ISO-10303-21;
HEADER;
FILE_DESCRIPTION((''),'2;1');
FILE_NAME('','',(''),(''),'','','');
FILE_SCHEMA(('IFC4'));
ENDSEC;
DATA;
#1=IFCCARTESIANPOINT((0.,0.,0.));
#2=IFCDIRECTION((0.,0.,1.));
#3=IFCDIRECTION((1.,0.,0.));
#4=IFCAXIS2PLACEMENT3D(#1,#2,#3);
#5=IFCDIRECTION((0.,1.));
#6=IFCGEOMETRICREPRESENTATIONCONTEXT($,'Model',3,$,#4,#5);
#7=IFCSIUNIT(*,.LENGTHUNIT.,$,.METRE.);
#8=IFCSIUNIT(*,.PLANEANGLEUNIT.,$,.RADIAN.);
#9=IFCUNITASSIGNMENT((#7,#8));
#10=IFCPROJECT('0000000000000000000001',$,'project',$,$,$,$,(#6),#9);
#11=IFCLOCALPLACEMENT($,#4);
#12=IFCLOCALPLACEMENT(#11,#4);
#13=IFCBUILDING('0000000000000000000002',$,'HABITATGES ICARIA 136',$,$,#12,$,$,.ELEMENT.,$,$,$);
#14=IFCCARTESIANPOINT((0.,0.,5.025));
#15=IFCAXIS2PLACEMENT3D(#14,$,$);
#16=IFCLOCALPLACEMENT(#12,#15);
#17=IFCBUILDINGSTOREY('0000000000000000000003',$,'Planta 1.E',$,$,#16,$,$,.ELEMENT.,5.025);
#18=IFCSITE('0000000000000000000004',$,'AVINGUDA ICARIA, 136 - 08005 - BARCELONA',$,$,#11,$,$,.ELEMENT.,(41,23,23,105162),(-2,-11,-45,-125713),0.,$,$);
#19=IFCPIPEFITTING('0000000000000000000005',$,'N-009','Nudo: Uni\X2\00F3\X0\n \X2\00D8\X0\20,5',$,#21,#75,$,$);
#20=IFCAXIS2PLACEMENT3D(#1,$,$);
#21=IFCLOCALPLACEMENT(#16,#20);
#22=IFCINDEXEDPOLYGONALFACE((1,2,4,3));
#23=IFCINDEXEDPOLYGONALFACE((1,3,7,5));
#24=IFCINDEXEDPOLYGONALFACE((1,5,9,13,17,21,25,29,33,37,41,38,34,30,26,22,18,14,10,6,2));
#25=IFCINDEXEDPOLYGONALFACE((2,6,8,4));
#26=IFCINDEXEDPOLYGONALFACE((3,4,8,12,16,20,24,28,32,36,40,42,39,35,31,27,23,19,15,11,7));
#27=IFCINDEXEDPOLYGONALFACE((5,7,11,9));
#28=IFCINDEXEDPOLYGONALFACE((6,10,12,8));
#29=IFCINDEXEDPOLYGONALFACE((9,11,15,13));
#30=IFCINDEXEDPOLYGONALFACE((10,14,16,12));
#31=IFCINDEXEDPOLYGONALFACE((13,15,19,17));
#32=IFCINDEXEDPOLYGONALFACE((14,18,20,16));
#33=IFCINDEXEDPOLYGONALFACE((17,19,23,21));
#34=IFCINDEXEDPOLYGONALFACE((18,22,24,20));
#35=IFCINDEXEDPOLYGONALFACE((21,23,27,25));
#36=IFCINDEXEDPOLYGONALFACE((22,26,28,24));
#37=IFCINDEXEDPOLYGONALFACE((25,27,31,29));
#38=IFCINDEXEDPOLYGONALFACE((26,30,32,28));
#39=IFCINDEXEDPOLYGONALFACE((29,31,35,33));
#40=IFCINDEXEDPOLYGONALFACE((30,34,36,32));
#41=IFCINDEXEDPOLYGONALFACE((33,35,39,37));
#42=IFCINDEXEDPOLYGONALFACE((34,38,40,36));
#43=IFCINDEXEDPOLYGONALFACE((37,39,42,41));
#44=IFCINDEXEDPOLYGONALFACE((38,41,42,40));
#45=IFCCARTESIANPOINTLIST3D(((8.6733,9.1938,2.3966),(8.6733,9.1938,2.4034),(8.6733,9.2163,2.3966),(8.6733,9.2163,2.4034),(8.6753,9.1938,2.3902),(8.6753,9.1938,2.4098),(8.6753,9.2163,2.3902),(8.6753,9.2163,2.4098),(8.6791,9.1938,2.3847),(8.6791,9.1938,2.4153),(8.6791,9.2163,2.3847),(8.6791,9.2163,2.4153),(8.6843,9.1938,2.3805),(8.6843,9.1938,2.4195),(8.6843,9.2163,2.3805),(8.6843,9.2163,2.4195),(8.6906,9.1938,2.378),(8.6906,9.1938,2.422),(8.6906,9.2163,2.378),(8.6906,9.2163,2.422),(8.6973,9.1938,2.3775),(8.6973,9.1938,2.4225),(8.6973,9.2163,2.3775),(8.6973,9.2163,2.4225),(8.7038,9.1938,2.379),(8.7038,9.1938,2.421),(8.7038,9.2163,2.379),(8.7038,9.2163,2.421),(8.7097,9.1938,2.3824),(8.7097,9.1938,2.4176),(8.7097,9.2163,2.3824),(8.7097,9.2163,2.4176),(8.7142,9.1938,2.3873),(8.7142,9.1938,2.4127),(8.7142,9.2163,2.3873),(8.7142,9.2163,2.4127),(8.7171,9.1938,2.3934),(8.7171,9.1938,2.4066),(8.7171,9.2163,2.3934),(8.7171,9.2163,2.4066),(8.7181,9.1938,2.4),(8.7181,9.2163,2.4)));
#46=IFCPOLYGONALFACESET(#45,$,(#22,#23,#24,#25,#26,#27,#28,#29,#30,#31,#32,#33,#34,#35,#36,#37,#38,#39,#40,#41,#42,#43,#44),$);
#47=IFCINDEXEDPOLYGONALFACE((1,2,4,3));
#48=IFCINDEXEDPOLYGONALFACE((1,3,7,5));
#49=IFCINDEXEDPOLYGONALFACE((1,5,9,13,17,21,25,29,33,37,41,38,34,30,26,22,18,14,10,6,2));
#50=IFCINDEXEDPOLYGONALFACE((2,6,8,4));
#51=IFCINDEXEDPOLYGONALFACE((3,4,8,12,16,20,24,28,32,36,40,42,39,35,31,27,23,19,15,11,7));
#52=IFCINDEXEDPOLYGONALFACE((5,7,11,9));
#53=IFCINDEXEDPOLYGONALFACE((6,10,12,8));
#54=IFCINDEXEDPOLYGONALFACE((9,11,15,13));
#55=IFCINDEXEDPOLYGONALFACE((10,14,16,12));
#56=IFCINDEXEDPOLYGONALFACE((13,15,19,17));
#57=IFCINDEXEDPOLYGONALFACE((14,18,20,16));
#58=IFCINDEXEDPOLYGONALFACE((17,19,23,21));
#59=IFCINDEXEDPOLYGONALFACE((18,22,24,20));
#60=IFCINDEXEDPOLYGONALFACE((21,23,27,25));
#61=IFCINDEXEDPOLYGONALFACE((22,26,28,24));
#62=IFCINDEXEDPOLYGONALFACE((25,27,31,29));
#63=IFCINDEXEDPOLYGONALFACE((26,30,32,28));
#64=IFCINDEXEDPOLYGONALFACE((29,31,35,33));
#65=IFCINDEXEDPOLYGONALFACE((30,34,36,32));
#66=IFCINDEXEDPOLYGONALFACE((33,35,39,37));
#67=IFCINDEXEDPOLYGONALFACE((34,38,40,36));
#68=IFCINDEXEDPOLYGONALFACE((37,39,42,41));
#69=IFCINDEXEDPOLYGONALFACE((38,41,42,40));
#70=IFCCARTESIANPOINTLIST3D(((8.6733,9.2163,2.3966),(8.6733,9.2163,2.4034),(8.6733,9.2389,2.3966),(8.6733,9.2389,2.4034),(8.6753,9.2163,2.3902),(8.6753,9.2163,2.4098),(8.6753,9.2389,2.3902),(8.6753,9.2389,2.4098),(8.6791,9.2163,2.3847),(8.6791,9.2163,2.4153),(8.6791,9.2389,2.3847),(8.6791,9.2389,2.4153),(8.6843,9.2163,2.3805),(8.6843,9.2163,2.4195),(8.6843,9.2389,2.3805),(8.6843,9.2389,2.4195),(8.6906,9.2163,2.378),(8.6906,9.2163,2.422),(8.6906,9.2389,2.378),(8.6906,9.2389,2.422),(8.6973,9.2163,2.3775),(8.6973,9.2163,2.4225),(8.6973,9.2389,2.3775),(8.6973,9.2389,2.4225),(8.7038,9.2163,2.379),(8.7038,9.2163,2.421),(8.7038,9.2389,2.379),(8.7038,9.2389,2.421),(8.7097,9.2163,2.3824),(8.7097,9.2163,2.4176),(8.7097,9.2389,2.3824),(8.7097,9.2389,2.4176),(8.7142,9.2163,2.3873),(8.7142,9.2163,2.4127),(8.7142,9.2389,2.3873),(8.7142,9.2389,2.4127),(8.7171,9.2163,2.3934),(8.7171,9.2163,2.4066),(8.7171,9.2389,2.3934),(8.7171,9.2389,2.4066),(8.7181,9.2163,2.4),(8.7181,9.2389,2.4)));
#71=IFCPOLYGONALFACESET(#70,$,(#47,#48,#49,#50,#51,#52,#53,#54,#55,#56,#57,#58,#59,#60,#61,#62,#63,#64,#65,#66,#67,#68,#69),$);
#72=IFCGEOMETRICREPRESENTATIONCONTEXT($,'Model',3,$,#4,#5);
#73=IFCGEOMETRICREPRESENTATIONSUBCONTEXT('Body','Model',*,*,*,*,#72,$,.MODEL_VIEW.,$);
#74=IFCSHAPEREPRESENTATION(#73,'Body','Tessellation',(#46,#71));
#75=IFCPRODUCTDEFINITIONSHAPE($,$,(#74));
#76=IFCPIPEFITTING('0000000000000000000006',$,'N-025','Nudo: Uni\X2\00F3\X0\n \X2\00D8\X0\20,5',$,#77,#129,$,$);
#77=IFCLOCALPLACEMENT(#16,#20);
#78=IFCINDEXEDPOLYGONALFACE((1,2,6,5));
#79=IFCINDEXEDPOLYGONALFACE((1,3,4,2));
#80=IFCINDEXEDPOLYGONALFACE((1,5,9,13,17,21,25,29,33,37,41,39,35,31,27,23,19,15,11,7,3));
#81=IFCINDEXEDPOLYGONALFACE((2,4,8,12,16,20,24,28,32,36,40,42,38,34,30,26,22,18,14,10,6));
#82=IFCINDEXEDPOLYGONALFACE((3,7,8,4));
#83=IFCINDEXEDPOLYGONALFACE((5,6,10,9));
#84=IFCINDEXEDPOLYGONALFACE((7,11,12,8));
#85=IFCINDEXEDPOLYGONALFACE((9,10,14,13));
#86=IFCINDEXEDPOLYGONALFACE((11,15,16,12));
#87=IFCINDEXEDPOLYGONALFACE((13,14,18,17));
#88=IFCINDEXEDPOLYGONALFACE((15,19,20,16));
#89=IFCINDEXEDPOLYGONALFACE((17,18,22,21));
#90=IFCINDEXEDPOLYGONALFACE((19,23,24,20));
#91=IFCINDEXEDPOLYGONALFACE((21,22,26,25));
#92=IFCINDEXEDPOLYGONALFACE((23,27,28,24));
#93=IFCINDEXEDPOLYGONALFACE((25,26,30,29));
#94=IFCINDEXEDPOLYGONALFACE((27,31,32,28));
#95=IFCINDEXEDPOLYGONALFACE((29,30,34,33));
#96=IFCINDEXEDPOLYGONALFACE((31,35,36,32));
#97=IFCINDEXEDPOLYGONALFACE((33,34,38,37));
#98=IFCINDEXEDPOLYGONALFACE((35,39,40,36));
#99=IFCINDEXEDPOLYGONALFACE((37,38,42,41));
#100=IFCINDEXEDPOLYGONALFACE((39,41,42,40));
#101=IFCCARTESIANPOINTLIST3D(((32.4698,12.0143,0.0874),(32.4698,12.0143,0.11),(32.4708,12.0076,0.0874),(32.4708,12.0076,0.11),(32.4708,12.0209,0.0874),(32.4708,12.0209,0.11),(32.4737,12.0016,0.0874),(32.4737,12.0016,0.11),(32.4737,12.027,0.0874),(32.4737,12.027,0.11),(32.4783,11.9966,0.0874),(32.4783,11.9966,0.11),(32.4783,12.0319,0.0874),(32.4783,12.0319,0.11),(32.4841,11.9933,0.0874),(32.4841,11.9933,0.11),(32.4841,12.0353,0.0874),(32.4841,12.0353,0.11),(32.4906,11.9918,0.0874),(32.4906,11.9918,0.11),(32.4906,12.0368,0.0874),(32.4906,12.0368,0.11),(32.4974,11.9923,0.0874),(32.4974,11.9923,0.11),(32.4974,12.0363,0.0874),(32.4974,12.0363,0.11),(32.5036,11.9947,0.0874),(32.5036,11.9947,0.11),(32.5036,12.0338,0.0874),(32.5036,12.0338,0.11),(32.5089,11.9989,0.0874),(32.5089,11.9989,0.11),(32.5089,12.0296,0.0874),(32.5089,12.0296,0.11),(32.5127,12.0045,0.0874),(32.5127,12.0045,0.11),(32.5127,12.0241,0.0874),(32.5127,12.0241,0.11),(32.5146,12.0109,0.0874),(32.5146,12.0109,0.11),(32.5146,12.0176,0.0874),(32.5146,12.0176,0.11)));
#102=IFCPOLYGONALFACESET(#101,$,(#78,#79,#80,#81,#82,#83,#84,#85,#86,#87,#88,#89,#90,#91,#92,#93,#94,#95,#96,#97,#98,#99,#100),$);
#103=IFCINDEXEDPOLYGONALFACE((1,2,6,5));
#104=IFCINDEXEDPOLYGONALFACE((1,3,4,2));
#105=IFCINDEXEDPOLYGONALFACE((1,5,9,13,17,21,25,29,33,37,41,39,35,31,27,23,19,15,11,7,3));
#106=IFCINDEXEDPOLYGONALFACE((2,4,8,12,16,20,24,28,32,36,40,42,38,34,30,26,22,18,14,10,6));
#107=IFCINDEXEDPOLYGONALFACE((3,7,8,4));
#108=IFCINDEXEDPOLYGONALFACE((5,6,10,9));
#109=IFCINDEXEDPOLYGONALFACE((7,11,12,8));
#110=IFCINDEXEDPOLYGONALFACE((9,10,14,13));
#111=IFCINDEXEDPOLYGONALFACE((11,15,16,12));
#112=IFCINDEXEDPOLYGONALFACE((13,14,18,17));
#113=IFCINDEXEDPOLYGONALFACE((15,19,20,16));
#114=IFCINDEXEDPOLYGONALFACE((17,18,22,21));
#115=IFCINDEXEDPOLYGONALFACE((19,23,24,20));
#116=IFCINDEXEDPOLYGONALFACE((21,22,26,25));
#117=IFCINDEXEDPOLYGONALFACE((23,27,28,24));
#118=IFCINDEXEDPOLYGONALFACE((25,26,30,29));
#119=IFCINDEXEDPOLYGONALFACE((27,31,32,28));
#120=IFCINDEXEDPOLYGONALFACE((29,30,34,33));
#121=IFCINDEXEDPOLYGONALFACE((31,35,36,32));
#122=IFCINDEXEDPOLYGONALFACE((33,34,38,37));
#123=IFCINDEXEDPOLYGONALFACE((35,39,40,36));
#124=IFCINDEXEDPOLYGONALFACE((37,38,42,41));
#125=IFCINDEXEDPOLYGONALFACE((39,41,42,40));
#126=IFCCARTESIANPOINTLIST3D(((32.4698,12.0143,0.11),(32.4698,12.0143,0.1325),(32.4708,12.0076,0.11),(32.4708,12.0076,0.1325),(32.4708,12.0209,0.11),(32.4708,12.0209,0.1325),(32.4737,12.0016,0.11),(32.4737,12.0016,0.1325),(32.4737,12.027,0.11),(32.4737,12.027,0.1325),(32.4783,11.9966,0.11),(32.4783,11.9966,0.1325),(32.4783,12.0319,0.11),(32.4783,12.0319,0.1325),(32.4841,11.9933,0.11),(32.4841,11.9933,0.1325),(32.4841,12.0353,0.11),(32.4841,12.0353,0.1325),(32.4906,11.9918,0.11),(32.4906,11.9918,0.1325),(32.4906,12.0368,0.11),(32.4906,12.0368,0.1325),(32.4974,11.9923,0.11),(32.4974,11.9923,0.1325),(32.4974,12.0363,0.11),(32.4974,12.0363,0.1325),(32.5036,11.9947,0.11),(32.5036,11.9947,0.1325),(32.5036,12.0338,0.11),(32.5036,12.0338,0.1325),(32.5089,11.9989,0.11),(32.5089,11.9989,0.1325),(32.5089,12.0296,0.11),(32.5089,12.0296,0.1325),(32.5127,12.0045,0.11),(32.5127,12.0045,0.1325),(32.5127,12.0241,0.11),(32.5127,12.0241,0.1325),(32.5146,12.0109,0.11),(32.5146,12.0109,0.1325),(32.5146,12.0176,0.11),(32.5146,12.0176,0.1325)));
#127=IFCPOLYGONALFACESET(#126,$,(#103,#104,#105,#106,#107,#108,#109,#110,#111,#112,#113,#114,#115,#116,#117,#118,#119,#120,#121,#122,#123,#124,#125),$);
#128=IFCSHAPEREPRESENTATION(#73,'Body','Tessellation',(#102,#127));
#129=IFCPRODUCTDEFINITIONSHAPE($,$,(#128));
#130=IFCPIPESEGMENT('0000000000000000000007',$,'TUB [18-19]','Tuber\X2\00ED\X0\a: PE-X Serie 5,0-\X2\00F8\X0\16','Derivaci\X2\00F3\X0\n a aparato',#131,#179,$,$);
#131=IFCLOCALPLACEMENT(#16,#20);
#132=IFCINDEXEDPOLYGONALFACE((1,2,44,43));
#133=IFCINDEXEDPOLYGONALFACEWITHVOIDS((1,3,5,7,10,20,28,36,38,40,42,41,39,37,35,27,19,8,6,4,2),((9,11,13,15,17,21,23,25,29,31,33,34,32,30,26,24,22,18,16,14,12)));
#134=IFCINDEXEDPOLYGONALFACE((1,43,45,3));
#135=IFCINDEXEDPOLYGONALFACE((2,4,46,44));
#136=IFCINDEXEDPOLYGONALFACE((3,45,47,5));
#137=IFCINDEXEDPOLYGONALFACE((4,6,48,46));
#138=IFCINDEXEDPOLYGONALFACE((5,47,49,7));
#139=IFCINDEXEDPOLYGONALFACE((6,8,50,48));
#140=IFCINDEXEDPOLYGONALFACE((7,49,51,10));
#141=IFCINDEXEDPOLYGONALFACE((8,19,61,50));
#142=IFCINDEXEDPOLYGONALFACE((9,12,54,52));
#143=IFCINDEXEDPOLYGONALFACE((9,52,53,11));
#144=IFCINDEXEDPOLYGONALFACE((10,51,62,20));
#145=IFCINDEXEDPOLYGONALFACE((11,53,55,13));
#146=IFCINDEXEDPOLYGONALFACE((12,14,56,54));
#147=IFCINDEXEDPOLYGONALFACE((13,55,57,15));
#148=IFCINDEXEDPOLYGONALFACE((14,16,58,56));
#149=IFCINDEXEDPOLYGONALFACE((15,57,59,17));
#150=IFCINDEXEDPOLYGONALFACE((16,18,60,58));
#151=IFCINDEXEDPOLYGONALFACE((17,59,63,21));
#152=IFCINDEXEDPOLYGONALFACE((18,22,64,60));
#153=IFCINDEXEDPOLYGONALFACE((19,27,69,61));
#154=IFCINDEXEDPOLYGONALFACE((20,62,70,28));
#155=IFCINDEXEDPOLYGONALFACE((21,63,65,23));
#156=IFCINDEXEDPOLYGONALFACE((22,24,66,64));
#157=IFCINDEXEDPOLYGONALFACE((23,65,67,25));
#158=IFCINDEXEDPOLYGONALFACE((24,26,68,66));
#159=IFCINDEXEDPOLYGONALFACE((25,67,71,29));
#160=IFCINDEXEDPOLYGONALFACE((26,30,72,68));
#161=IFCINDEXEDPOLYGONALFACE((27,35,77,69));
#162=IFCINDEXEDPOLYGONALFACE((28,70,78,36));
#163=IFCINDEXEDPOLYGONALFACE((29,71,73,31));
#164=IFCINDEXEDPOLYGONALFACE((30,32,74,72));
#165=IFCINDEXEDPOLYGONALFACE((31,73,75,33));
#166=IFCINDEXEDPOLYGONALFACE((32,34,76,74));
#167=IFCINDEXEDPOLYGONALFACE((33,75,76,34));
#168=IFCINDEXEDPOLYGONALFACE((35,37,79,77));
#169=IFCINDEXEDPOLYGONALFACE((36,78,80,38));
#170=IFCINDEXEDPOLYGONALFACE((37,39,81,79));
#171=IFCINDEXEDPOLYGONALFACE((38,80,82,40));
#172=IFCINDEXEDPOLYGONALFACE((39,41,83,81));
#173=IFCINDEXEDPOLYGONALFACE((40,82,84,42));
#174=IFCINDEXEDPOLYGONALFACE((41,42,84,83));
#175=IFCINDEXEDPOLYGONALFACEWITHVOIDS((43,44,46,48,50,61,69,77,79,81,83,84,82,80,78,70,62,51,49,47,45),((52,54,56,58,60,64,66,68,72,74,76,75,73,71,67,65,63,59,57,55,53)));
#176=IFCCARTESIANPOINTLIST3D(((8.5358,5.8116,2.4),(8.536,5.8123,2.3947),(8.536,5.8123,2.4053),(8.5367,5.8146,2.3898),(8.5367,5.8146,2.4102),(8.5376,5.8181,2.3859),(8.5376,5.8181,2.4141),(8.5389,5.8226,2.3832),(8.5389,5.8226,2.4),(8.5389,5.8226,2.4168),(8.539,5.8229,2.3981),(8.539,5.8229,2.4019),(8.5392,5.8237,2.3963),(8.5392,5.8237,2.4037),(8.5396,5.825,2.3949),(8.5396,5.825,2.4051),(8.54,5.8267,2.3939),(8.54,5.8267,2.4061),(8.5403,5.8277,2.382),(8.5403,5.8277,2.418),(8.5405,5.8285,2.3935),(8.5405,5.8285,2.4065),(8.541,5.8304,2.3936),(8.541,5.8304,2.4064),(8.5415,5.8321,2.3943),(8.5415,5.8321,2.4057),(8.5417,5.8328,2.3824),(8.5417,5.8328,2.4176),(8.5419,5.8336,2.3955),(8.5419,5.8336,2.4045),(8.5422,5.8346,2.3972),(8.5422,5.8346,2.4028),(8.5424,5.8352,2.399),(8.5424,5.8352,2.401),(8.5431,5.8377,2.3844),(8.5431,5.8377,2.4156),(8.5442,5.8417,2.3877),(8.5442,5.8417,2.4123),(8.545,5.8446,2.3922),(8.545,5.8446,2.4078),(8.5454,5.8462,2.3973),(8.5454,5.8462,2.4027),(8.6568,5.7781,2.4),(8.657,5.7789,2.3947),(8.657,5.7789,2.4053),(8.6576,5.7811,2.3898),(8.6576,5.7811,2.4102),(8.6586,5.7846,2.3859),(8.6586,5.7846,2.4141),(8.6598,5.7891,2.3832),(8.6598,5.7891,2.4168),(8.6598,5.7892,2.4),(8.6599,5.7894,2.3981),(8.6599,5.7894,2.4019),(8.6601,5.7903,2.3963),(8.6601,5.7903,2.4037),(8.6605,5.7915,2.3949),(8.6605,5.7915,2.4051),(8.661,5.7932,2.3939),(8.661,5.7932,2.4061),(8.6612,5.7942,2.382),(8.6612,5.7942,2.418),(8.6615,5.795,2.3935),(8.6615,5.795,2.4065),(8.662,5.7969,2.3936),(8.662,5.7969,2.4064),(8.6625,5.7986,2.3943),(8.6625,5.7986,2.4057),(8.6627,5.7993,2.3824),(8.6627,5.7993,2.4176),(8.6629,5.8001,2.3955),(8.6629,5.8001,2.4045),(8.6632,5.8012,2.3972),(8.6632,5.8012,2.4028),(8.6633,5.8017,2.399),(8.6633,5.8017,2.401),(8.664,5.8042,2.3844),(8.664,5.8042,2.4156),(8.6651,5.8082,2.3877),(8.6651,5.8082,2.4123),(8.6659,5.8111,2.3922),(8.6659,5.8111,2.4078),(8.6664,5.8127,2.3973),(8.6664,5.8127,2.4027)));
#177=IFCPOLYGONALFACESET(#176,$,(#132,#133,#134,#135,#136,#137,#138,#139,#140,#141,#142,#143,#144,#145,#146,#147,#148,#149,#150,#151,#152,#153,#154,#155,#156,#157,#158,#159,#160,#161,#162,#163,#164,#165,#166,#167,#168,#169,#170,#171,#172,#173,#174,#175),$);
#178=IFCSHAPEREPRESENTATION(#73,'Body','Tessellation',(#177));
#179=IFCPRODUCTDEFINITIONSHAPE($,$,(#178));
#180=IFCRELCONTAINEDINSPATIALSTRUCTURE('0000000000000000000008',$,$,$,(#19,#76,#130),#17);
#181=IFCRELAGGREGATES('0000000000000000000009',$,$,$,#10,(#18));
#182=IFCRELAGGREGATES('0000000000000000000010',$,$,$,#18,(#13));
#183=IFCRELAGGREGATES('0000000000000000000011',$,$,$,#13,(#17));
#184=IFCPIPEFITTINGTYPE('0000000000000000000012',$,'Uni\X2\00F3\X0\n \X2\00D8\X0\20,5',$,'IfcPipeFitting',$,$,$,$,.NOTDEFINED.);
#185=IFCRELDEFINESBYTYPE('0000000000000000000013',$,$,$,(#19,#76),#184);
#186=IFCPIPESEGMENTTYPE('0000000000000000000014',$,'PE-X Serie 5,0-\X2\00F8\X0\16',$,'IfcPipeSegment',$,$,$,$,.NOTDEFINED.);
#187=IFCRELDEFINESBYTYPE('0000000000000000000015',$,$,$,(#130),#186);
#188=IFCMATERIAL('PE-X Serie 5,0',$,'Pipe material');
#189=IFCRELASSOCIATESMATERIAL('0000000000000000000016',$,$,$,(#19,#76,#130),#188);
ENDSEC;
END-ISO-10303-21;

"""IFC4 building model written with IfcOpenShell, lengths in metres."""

from ifc_helpers import new_model, si_unit, direction, frame, origin_with_axes, origin_2d_with_axis, place, context, subcontext, project, spatial, circle, hollow_circle, extrude, source, transform, mapped, material, type_object, element, save


model = new_model("IFC4")

# Units and contexts
model_context_1 = context("Model", 3, world=origin_with_axes(), true_north=direction((0.0, 1.0)))
model_context_2 = context("Model", 3, world=origin_with_axes(), true_north=direction((0.0, 1.0)))
body_context_1 = subcontext(model_context_2, "Body", "Model", "MODEL_VIEW")
ifc_project = project(units=[si_unit("LENGTHUNIT", "METRE"), si_unit("PLANEANGLEUNIT", "RADIAN")], contexts=[model_context_1])

# Site, building, storey
site_placement = place(None, origin_with_axes())
site = spatial("IfcSite", under=ifc_project, at=site_placement, Name="AVINGUDA ICARIA, 136 - 08005 - BARCELONA", CompositionType="ELEMENT", RefLatitude=(41, 23, 23, 105162), RefLongitude=(-2, -11, -45, -125713), RefElevation=0.0)
building_placement = place(site_placement, origin_with_axes())
building = spatial("IfcBuilding", under=site, at=building_placement, Name="HABITATGES ICARIA 136", CompositionType="ELEMENT")
storey_placement = place(building_placement, frame((0.0, 0.0, 5.025)))
storey = spatial("IfcBuildingStorey", under=building, at=storey_placement, Name="Planta 1.E", CompositionType="ELEMENT", Elevation=5.025)

# Shared definitions
ifc_material_1 = material(Name="PE-X Serie 5,0", Category="Pipe material")
placement_1 = place(None, origin_with_axes())
placement_2 = place(placement_1, origin_with_axes())
placement_3 = place(placement_2, frame((0.0, 0.0, 5.025)))

# Pipe fittings
pipe_fitting_type_1 = type_object("IfcPipeFittingType", Name="Unión Ø20,5", ApplicableOccurrence="IfcPipeFitting", PredefinedType="NOTDEFINED")
shared_shape_1 = source(origin_with_axes(), body_context_1, "Body", "SweptSolid", [
    extrude(circle(Radius=0.0226, at=origin_2d_with_axis()), frame((0.0, 0.0, 0.0), z_axis=(0.0, 1.0, 0.0), x_axis=(-1.0, 0.0, 0.0)), (0.0, 0.0, 1.0), 0.0226),
    extrude(circle(Radius=0.0226, at=origin_2d_with_axis()), frame((0.0, -0.0226, 0.0), z_axis=(0.0, 1.0, 0.0), x_axis=(-1.0, 0.0, 0.0)), (0.0, 0.0, 1.0), 0.0226),
])
pipe_fitting_1_placement = place(placement_3, origin_with_axes())
element("IfcPipeFitting", 1, at=pipe_fitting_1_placement, inside=storey, type_object=pipe_fitting_type_1, material=ifc_material_1, Name="N-009", Description="Nudo: Unión Ø20,5", context=body_context_1, shape_type="MappedRepresentation", body=[
    mapped(shared_shape_1, transform((8.6956, 9.2163, 2.4), x_axis=(-1.0, 0.0, 0.0), y_axis=(0.0, -1.0, 0.0), z_axis=(0.0, 0.0, 1.0), scale=1.0)),
])
pipe_fitting_2_placement = place(placement_3, origin_with_axes())
element("IfcPipeFitting", 2, at=pipe_fitting_2_placement, inside=storey, type_object=pipe_fitting_type_1, material=ifc_material_1, Name="N-025", Description="Nudo: Unión Ø20,5", context=body_context_1, shape_type="MappedRepresentation", body=[
    mapped(shared_shape_1, transform((32.4923, 12.0143, 0.11), x_axis=(1.0, 0.0, 0.0), y_axis=(0.0, 0.0, -1.0), z_axis=(0.0, 1.0, 0.0), scale=1.0)),
])

# Pipe segment
pipe_segment_type_1 = type_object("IfcPipeSegmentType", Name="PE-X Serie 5,0-ø16", ApplicableOccurrence="IfcPipeSegment", PredefinedType="NOTDEFINED")
pipe_segment_1_placement = place(placement_3, frame((0.0, 0.0, -5.025), z_axis=(0.0, 0.0, 1.0), x_axis=(1.0, 0.0, 0.0)))
element("IfcPipeSegment", 3, at=pipe_segment_1_placement, inside=storey, type_object=pipe_segment_type_1, material=ifc_material_1, Name="TUB [18-19]", Description="Tubería: PE-X Serie 5,0-ø16", ObjectType="Derivación a aparato", context=body_context_1, shape_type="SweptSolid", body=[
    extrude(hollow_circle(Radius=0.0181, WallThickness=0.0115, at=origin_2d_with_axis()), frame((8.6616, 5.7955, 7.425), z_axis=(-0.96374, 0.266843, 0.0), x_axis=(-0.266843, -0.96374, 0.0)), (0.0, 0.0, 1.0), 0.1255),
])

save(model, "model.ifc")
